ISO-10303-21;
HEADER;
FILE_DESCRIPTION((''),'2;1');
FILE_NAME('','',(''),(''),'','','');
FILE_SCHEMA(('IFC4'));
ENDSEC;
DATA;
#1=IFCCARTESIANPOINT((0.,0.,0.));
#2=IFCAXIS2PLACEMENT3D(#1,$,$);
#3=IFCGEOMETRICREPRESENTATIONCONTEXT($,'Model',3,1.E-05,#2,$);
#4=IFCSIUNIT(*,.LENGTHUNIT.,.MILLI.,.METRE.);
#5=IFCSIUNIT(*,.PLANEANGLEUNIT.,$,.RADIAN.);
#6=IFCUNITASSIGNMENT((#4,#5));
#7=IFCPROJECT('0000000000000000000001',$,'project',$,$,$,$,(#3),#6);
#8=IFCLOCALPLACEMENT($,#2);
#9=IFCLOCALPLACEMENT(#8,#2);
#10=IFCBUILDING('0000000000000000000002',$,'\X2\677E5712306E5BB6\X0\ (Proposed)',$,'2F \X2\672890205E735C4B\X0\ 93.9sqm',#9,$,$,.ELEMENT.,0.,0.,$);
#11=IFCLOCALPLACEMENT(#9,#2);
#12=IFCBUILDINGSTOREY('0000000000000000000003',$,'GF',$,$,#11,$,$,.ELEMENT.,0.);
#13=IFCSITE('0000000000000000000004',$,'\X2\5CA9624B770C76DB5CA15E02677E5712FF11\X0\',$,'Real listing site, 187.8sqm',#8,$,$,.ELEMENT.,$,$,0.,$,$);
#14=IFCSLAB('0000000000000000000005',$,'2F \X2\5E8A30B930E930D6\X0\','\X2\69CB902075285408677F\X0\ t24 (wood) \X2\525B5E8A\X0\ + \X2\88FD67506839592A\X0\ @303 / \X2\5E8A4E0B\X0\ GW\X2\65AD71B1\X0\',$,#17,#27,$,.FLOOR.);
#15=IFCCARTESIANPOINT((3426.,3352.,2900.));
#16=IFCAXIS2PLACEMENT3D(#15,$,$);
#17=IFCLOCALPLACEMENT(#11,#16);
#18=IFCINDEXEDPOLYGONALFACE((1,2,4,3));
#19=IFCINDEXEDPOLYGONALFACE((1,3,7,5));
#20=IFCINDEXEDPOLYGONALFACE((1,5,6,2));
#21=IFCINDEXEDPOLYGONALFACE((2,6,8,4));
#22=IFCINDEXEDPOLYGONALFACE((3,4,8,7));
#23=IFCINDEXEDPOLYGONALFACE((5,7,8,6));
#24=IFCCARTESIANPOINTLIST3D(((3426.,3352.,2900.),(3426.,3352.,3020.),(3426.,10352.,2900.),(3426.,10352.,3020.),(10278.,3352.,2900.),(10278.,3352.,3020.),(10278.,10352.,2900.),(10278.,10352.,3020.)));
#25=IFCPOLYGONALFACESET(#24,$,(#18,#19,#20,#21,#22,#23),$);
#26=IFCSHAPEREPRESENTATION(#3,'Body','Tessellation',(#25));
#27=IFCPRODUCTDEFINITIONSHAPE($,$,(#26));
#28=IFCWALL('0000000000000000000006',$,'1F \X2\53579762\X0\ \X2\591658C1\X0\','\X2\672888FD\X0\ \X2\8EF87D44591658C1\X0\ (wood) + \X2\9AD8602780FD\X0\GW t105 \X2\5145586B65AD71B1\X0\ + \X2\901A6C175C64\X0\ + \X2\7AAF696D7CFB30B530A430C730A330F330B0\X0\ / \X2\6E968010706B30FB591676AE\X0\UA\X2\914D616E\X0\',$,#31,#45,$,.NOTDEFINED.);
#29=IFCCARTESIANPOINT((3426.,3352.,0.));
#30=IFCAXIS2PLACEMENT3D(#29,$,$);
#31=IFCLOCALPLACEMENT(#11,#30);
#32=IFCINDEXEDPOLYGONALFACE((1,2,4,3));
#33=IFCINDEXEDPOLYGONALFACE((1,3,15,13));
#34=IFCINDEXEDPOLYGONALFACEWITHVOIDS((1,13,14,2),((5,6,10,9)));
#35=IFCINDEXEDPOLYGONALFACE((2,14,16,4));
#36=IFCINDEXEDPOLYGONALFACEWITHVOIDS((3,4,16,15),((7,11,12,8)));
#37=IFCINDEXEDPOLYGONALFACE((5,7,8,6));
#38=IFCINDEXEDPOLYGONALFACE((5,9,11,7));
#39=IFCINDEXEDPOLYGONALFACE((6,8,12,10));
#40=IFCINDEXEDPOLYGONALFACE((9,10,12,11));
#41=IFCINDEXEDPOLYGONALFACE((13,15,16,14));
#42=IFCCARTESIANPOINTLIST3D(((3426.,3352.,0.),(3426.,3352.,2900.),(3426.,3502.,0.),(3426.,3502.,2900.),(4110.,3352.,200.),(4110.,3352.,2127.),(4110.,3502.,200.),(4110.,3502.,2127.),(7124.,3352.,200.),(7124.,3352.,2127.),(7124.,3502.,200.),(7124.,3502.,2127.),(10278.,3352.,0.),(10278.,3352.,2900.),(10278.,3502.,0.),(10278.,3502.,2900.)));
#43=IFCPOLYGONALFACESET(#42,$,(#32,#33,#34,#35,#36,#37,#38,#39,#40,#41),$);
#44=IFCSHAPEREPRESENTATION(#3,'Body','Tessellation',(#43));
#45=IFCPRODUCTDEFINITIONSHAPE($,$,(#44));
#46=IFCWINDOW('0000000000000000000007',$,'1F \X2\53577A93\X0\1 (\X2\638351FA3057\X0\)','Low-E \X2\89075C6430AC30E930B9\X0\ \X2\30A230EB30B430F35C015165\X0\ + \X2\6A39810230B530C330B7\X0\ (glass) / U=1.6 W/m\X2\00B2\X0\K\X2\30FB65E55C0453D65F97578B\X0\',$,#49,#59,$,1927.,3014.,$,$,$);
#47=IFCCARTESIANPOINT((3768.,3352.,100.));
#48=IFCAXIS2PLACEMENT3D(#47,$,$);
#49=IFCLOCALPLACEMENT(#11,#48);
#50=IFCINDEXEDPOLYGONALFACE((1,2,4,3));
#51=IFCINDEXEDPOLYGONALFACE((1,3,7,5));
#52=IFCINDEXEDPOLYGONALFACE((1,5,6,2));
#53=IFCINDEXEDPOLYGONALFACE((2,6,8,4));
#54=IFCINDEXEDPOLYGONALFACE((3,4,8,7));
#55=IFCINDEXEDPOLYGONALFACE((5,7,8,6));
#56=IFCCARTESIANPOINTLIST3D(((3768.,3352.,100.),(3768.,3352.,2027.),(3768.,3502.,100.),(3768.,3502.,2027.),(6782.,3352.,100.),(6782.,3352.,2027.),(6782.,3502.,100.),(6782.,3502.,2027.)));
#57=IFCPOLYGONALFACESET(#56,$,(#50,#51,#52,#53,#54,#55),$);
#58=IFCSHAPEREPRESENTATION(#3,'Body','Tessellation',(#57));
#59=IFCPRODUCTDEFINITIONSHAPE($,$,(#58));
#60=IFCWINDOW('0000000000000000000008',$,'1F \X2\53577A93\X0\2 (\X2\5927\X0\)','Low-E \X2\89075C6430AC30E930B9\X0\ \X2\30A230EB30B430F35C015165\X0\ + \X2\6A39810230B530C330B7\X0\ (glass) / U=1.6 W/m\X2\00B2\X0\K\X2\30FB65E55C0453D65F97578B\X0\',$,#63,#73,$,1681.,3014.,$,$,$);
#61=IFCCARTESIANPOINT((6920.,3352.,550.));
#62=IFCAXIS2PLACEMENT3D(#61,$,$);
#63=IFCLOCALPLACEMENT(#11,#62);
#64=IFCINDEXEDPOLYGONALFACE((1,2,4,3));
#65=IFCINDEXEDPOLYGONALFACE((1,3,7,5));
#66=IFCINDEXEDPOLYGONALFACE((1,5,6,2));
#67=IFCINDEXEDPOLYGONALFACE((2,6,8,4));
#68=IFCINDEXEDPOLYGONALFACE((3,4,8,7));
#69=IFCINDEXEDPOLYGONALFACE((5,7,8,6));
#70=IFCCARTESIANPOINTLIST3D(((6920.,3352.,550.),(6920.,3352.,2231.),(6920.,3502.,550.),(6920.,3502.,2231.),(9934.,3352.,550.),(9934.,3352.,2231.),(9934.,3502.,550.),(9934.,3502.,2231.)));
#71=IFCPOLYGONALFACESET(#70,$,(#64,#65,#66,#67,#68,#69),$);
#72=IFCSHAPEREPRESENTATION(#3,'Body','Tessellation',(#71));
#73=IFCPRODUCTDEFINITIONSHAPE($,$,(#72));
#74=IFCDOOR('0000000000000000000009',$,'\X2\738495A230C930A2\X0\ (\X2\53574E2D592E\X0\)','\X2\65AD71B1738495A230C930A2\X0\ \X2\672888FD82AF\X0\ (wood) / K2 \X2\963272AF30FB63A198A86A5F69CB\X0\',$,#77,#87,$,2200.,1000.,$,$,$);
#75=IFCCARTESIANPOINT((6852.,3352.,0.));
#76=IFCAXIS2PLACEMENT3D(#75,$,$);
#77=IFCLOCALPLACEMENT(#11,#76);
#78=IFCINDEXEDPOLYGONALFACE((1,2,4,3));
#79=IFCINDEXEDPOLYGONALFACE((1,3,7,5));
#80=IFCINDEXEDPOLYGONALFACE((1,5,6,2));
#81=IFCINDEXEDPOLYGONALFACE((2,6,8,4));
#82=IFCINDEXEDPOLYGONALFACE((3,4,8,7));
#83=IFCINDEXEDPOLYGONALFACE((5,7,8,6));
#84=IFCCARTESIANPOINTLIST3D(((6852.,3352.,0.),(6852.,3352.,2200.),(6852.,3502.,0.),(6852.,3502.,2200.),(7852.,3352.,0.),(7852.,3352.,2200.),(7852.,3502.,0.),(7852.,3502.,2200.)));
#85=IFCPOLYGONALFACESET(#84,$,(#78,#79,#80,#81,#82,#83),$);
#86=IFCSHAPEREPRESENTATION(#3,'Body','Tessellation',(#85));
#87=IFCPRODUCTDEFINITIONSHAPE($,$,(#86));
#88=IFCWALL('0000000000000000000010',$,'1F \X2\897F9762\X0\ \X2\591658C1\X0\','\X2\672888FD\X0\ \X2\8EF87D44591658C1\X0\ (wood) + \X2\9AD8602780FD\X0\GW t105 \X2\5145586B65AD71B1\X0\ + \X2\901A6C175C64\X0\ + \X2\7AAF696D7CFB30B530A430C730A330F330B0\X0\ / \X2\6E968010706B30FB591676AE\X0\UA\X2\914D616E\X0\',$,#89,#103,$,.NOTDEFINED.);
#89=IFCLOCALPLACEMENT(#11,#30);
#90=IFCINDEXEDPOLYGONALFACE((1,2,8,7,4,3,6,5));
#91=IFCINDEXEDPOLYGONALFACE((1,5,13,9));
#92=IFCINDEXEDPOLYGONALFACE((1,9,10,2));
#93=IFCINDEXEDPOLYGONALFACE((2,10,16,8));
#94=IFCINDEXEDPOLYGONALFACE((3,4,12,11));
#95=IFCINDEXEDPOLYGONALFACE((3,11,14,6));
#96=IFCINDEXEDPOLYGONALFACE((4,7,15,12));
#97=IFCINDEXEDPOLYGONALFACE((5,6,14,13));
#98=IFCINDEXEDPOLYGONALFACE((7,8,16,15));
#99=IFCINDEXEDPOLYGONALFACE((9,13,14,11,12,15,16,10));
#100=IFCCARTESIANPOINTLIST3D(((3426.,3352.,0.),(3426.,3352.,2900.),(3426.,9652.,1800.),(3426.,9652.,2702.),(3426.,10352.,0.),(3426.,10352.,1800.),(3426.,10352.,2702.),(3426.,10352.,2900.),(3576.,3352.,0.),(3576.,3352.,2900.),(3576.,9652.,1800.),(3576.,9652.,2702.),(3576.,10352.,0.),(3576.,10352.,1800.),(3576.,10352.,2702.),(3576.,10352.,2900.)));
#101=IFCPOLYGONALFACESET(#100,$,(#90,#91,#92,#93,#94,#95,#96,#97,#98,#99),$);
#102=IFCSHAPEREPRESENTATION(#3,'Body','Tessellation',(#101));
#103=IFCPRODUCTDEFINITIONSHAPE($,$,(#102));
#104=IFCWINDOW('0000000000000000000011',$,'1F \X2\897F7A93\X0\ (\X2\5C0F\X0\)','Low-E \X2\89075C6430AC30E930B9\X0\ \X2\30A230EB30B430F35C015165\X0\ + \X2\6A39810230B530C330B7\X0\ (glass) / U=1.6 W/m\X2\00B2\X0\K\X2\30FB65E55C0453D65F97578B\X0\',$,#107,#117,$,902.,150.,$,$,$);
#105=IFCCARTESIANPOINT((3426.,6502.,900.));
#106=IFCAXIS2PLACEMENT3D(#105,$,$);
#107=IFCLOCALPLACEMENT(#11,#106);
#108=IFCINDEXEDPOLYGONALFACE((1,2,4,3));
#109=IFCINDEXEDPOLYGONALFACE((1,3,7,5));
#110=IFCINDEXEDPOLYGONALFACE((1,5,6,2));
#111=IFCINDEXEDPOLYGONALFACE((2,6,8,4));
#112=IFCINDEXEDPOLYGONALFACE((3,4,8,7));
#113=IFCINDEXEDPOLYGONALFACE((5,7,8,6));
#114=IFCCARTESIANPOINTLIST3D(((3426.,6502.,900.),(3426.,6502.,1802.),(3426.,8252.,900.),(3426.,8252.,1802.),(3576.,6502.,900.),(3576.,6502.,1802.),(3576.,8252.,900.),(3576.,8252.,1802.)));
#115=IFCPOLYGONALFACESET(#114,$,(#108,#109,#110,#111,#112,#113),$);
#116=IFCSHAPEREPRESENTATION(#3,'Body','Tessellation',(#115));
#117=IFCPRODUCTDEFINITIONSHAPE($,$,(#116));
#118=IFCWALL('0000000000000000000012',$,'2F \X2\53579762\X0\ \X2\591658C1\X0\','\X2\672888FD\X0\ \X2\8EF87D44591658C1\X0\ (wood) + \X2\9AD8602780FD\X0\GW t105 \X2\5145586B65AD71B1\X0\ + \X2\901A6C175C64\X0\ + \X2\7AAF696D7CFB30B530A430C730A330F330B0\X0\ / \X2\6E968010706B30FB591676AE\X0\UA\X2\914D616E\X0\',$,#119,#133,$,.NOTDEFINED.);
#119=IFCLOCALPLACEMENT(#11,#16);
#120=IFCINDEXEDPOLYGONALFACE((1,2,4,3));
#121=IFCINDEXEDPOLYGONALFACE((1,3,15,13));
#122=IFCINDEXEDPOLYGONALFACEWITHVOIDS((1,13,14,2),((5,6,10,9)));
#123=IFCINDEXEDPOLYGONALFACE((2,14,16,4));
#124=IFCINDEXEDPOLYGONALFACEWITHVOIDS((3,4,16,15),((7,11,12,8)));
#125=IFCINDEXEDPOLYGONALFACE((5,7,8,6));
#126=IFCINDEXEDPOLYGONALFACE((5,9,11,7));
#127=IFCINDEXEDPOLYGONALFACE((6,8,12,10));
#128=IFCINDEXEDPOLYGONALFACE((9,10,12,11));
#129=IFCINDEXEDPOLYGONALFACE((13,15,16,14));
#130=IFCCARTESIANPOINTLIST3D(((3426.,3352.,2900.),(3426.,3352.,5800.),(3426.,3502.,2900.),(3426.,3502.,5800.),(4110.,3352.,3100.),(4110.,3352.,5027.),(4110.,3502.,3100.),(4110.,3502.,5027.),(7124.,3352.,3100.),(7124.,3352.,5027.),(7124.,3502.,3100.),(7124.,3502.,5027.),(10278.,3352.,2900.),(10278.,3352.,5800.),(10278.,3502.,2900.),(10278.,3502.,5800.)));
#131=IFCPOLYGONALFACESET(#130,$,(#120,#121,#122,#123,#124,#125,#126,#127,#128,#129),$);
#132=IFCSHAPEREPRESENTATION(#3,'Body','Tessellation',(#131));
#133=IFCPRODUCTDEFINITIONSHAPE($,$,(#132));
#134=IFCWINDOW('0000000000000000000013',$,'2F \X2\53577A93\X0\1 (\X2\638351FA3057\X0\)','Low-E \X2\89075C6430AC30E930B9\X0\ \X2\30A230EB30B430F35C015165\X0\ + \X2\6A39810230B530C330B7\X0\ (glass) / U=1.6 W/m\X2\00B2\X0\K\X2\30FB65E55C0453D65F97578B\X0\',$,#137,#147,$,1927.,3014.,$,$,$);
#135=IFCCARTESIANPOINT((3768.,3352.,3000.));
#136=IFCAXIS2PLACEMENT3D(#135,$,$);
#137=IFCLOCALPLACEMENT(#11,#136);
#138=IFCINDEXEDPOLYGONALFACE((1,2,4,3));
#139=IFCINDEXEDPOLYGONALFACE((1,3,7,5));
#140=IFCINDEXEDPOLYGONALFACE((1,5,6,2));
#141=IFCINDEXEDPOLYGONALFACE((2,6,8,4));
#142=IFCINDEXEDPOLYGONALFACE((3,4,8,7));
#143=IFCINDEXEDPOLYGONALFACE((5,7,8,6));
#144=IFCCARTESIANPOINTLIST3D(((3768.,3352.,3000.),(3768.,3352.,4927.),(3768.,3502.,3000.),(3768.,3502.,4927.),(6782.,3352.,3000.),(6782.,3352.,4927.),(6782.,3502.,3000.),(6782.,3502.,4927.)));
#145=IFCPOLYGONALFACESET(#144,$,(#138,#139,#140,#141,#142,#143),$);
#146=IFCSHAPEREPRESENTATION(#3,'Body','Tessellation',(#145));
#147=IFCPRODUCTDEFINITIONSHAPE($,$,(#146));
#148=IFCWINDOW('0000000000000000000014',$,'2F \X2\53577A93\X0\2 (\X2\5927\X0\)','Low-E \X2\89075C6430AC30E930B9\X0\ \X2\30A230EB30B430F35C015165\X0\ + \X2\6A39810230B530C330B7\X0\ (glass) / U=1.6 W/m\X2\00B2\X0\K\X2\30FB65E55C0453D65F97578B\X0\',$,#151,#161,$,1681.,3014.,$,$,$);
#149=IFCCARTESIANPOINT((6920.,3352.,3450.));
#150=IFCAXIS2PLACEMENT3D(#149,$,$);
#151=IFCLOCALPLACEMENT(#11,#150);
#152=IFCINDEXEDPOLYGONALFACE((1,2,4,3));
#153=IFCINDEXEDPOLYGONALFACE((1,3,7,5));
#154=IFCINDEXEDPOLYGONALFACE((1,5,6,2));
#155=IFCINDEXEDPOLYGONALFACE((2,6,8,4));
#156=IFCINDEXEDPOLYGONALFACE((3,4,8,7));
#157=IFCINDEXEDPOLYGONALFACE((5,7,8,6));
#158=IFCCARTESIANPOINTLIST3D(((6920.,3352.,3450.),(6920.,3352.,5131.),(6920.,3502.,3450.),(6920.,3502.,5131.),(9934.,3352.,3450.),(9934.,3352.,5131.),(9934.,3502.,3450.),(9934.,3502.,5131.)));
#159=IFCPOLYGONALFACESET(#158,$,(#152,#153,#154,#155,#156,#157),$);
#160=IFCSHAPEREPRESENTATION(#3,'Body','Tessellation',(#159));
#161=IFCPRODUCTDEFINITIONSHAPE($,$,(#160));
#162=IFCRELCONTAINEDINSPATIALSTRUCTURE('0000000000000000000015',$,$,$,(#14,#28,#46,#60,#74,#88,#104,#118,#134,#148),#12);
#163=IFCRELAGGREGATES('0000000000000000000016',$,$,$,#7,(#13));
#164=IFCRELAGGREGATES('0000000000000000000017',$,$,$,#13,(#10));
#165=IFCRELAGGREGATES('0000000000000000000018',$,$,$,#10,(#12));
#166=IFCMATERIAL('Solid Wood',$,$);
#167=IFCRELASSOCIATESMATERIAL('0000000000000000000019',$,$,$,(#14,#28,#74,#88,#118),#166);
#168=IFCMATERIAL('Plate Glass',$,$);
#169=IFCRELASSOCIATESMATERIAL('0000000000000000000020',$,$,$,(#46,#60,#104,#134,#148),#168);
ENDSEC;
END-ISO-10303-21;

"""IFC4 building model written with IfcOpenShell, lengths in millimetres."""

from ifc_helpers import new_model, si_unit, frame, frame_2d, origin, place, context, project, spatial, rectangle, extrude, material, element, fill, save


model = new_model("IFC4")

# Units and contexts
model_context = context("Model", 3, precision=1e-05, world=origin())
ifc_project = project(units=[si_unit("LENGTHUNIT", "METRE", prefix="MILLI"), si_unit("PLANEANGLEUNIT", "RADIAN")], contexts=[model_context])

# Site, building, storey
site_placement = place(None, origin())
site = spatial("IfcSite", under=ifc_project, at=site_placement, Name="岩手県盛岡市松園１", ObjectType="Real listing site, 187.8sqm", CompositionType="ELEMENT", RefElevation=0.0)
building_placement = place(site_placement, origin())
building = spatial("IfcBuilding", under=site, at=building_placement, Name="松園の家 (Proposed)", ObjectType="2F 木造平屋 93.9sqm", CompositionType="ELEMENT", ElevationOfRefHeight=0.0, ElevationOfTerrain=0.0)
storey_placement = place(building_placement, origin())
storey = spatial("IfcBuildingStorey", under=building, at=storey_placement, Name="GF", CompositionType="ELEMENT", Elevation=0.0)

# Slab
ifc_material_1 = material(Name="Solid Wood")
slab_1_placement = place(storey_placement, frame((3426.0, 3352.0, 2900.0)))
element("IfcSlab", 1, at=slab_1_placement, inside=storey, material=ifc_material_1, Name="2F 床スラブ", Description="構造用合板 t24 (wood) 剛床 + 製材根太 @303 / 床下 GW断熱", PredefinedType="FLOOR", context=model_context, shape_type="SweptSolid", body=[
    extrude(rectangle(XDim=6852.0, YDim=7000.0, at=frame_2d((3426.0, 3500.0))), frame((3426.0, 3352.0, 2900.0)), (0.0, 0.0, 1.0), 120.0),
])

# Wall, openings, windows, door
wall_1_placement = place(storey_placement, frame((3426.0, 3352.0, 0.0)))
wall_1 = element("IfcWall", 2, at=wall_1_placement, inside=storey, material=ifc_material_1, Name="1F 南面 外壁", Description="木製 軸組外壁 (wood) + 高性能GW t105 充填断熱 + 通気層 + 窯業系サイディング / 準耐火・外皮UA配慮", PredefinedType="NOTDEFINED", context=model_context, shape_type="SweptSolid", body=[
    extrude(rectangle(XDim=6852.0, YDim=150.0, at=frame_2d((3426.0, 75.0))), frame((3426.0, 3352.0, 0.0)), (0.0, 0.0, 1.0), 2900.0),
])
opening_1_placement = place(storey_placement, frame((3768.0, 3352.0, 100.0)))
opening_1 = element("IfcOpeningElement", 3, at=opening_1_placement, cuts=wall_1, PredefinedType="NOTDEFINED", context=model_context, shape_type="SweptSolid", body=[
    extrude(rectangle(XDim=3014.0, YDim=150.0, at=frame_2d((1507.0, 75.0))), frame((3768.0, 3352.0, 100.0)), (0.0, 0.0, 1.0), 1927.0),
])
opening_2_placement = place(storey_placement, frame((6920.0, 3352.0, 550.0)))
opening_2 = element("IfcOpeningElement", 4, at=opening_2_placement, cuts=wall_1, PredefinedType="NOTDEFINED", context=model_context, shape_type="SweptSolid", body=[
    extrude(rectangle(XDim=3014.0, YDim=150.0, at=frame_2d((1507.0, 75.0))), frame((6920.0, 3352.0, 550.0)), (0.0, 0.0, 1.0), 1681.0),
])
opening_3_placement = place(storey_placement, frame((6852.0, 3352.0, 0.0)))
opening_3 = element("IfcOpeningElement", 5, at=opening_3_placement, cuts=wall_1, PredefinedType="NOTDEFINED", context=model_context, shape_type="SweptSolid", body=[
    extrude(rectangle(XDim=1000.0, YDim=150.0, at=frame_2d((500.0, 75.0))), frame((6852.0, 3352.0, 0.0)), (0.0, 0.0, 1.0), 2200.0),
])
ifc_material_2 = material(Name="Plate Glass")
window_1_placement = place(storey_placement, frame((3768.0, 3352.0, 100.0)))
window_1 = element("IfcWindow", 6, at=window_1_placement, inside=storey, material=ifc_material_2, Name="1F 南窓1 (掃出し)", Description="Low-E 複層ガラス アルゴン封入 + 樹脂サッシ (glass) / U=1.6 W/m²K・日射取得型", OverallHeight=1927.0, OverallWidth=3014.0, context=model_context, shape_type="SweptSolid", body=[
    extrude(rectangle(XDim=3014.0, YDim=150.0, at=frame_2d((1507.0, 75.0))), frame((3768.0, 3352.0, 100.0)), (0.0, 0.0, 1.0), 1927.0),
])
fill(opening_1, window_1)
window_2_placement = place(storey_placement, frame((6920.0, 3352.0, 550.0)))
window_2 = element("IfcWindow", 7, at=window_2_placement, inside=storey, material=ifc_material_2, Name="1F 南窓2 (大)", Description="Low-E 複層ガラス アルゴン封入 + 樹脂サッシ (glass) / U=1.6 W/m²K・日射取得型", OverallHeight=1681.0, OverallWidth=3014.0, context=model_context, shape_type="SweptSolid", body=[
    extrude(rectangle(XDim=3014.0, YDim=150.0, at=frame_2d((1507.0, 75.0))), frame((6920.0, 3352.0, 550.0)), (0.0, 0.0, 1.0), 1681.0),
])
fill(opening_2, window_2)
door_placement = place(storey_placement, frame((6852.0, 3352.0, 0.0)))
door = element("IfcDoor", 8, at=door_placement, inside=storey, material=ifc_material_1, Name="玄関ドア (南中央)", Description="断熱玄関ドア 木製芯 (wood) / K2 防犯・採風機構", OverallHeight=2200.0, OverallWidth=1000.0, context=model_context, shape_type="SweptSolid", body=[
    extrude(rectangle(XDim=1000.0, YDim=150.0, at=frame_2d((500.0, 75.0))), frame((6852.0, 3352.0, 0.0)), (0.0, 0.0, 1.0), 2200.0),
])
fill(opening_3, door)

# Wall, opening, window
wall_2_placement = place(storey_placement, frame((3426.0, 3352.0, 0.0)))
wall_2 = element("IfcWall", 9, at=wall_2_placement, inside=storey, material=ifc_material_1, Name="1F 西面 外壁", Description="木製 軸組外壁 (wood) + 高性能GW t105 充填断熱 + 通気層 + 窯業系サイディング / 準耐火・外皮UA配慮", PredefinedType="NOTDEFINED", context=model_context, shape_type="SweptSolid", body=[
    extrude(rectangle(XDim=150.0, YDim=7000.0, at=frame_2d((75.0, 3500.0))), frame((3426.0, 3352.0, 0.0)), (0.0, 0.0, 1.0), 2900.0),
])
opening_4_placement = place(storey_placement, frame((3426.0, 6502.0, 900.0)))
opening_4 = element("IfcOpeningElement", 10, at=opening_4_placement, cuts=wall_2, PredefinedType="NOTDEFINED", context=model_context, shape_type="SweptSolid", body=[
    extrude(rectangle(XDim=150.0, YDim=1750.0, at=frame_2d((75.0, 875.0))), frame((3426.0, 6502.0, 900.0)), (0.0, 0.0, 1.0), 902.0),
])
window_3_placement = place(storey_placement, frame((3426.0, 6502.0, 900.0)))
window_3 = element("IfcWindow", 11, at=window_3_placement, inside=storey, material=ifc_material_2, Name="1F 西窓 (小)", Description="Low-E 複層ガラス アルゴン封入 + 樹脂サッシ (glass) / U=1.6 W/m²K・日射取得型", OverallHeight=902.0, OverallWidth=150.0, context=model_context, shape_type="SweptSolid", body=[
    extrude(rectangle(XDim=150.0, YDim=1750.0, at=frame_2d((75.0, 875.0))), frame((3426.0, 6502.0, 900.0)), (0.0, 0.0, 1.0), 902.0),
])
fill(opening_4, window_3)

# Wall, openings, windows
wall_3_placement = place(storey_placement, frame((3426.0, 3352.0, 2900.0)))
wall_3 = element("IfcWall", 12, at=wall_3_placement, inside=storey, material=ifc_material_1, Name="2F 南面 外壁", Description="木製 軸組外壁 (wood) + 高性能GW t105 充填断熱 + 通気層 + 窯業系サイディング / 準耐火・外皮UA配慮", PredefinedType="NOTDEFINED", context=model_context, shape_type="SweptSolid", body=[
    extrude(rectangle(XDim=6852.0, YDim=150.0, at=frame_2d((3426.0, 75.0))), frame((3426.0, 3352.0, 2900.0)), (0.0, 0.0, 1.0), 2900.0),
])
opening_5_placement = place(storey_placement, frame((3768.0, 3352.0, 3000.0)))
opening_5 = element("IfcOpeningElement", 13, at=opening_5_placement, cuts=wall_3, PredefinedType="NOTDEFINED", context=model_context, shape_type="SweptSolid", body=[
    extrude(rectangle(XDim=3014.0, YDim=150.0, at=frame_2d((1507.0, 75.0))), frame((3768.0, 3352.0, 3000.0)), (0.0, 0.0, 1.0), 1927.0),
])
opening_6_placement = place(storey_placement, frame((6920.0, 3352.0, 3450.0)))
opening_6 = element("IfcOpeningElement", 14, at=opening_6_placement, cuts=wall_3, PredefinedType="NOTDEFINED", context=model_context, shape_type="SweptSolid", body=[
    extrude(rectangle(XDim=3014.0, YDim=150.0, at=frame_2d((1507.0, 75.0))), frame((6920.0, 3352.0, 3450.0)), (0.0, 0.0, 1.0), 1681.0),
])
window_4_placement = place(storey_placement, frame((3768.0, 3352.0, 3000.0)))
window_4 = element("IfcWindow", 15, at=window_4_placement, inside=storey, material=ifc_material_2, Name="2F 南窓1 (掃出し)", Description="Low-E 複層ガラス アルゴン封入 + 樹脂サッシ (glass) / U=1.6 W/m²K・日射取得型", OverallHeight=1927.0, OverallWidth=3014.0, context=model_context, shape_type="SweptSolid", body=[
    extrude(rectangle(XDim=3014.0, YDim=150.0, at=frame_2d((1507.0, 75.0))), frame((3768.0, 3352.0, 3000.0)), (0.0, 0.0, 1.0), 1927.0),
])
fill(opening_5, window_4)
window_5_placement = place(storey_placement, frame((6920.0, 3352.0, 3450.0)))
window_5 = element("IfcWindow", 16, at=window_5_placement, inside=storey, material=ifc_material_2, Name="2F 南窓2 (大)", Description="Low-E 複層ガラス アルゴン封入 + 樹脂サッシ (glass) / U=1.6 W/m²K・日射取得型", OverallHeight=1681.0, OverallWidth=3014.0, context=model_context, shape_type="SweptSolid", body=[
    extrude(rectangle(XDim=3014.0, YDim=150.0, at=frame_2d((1507.0, 75.0))), frame((6920.0, 3352.0, 3450.0)), (0.0, 0.0, 1.0), 1681.0),
])
fill(opening_6, window_5)

save(model, "model.ifc")
